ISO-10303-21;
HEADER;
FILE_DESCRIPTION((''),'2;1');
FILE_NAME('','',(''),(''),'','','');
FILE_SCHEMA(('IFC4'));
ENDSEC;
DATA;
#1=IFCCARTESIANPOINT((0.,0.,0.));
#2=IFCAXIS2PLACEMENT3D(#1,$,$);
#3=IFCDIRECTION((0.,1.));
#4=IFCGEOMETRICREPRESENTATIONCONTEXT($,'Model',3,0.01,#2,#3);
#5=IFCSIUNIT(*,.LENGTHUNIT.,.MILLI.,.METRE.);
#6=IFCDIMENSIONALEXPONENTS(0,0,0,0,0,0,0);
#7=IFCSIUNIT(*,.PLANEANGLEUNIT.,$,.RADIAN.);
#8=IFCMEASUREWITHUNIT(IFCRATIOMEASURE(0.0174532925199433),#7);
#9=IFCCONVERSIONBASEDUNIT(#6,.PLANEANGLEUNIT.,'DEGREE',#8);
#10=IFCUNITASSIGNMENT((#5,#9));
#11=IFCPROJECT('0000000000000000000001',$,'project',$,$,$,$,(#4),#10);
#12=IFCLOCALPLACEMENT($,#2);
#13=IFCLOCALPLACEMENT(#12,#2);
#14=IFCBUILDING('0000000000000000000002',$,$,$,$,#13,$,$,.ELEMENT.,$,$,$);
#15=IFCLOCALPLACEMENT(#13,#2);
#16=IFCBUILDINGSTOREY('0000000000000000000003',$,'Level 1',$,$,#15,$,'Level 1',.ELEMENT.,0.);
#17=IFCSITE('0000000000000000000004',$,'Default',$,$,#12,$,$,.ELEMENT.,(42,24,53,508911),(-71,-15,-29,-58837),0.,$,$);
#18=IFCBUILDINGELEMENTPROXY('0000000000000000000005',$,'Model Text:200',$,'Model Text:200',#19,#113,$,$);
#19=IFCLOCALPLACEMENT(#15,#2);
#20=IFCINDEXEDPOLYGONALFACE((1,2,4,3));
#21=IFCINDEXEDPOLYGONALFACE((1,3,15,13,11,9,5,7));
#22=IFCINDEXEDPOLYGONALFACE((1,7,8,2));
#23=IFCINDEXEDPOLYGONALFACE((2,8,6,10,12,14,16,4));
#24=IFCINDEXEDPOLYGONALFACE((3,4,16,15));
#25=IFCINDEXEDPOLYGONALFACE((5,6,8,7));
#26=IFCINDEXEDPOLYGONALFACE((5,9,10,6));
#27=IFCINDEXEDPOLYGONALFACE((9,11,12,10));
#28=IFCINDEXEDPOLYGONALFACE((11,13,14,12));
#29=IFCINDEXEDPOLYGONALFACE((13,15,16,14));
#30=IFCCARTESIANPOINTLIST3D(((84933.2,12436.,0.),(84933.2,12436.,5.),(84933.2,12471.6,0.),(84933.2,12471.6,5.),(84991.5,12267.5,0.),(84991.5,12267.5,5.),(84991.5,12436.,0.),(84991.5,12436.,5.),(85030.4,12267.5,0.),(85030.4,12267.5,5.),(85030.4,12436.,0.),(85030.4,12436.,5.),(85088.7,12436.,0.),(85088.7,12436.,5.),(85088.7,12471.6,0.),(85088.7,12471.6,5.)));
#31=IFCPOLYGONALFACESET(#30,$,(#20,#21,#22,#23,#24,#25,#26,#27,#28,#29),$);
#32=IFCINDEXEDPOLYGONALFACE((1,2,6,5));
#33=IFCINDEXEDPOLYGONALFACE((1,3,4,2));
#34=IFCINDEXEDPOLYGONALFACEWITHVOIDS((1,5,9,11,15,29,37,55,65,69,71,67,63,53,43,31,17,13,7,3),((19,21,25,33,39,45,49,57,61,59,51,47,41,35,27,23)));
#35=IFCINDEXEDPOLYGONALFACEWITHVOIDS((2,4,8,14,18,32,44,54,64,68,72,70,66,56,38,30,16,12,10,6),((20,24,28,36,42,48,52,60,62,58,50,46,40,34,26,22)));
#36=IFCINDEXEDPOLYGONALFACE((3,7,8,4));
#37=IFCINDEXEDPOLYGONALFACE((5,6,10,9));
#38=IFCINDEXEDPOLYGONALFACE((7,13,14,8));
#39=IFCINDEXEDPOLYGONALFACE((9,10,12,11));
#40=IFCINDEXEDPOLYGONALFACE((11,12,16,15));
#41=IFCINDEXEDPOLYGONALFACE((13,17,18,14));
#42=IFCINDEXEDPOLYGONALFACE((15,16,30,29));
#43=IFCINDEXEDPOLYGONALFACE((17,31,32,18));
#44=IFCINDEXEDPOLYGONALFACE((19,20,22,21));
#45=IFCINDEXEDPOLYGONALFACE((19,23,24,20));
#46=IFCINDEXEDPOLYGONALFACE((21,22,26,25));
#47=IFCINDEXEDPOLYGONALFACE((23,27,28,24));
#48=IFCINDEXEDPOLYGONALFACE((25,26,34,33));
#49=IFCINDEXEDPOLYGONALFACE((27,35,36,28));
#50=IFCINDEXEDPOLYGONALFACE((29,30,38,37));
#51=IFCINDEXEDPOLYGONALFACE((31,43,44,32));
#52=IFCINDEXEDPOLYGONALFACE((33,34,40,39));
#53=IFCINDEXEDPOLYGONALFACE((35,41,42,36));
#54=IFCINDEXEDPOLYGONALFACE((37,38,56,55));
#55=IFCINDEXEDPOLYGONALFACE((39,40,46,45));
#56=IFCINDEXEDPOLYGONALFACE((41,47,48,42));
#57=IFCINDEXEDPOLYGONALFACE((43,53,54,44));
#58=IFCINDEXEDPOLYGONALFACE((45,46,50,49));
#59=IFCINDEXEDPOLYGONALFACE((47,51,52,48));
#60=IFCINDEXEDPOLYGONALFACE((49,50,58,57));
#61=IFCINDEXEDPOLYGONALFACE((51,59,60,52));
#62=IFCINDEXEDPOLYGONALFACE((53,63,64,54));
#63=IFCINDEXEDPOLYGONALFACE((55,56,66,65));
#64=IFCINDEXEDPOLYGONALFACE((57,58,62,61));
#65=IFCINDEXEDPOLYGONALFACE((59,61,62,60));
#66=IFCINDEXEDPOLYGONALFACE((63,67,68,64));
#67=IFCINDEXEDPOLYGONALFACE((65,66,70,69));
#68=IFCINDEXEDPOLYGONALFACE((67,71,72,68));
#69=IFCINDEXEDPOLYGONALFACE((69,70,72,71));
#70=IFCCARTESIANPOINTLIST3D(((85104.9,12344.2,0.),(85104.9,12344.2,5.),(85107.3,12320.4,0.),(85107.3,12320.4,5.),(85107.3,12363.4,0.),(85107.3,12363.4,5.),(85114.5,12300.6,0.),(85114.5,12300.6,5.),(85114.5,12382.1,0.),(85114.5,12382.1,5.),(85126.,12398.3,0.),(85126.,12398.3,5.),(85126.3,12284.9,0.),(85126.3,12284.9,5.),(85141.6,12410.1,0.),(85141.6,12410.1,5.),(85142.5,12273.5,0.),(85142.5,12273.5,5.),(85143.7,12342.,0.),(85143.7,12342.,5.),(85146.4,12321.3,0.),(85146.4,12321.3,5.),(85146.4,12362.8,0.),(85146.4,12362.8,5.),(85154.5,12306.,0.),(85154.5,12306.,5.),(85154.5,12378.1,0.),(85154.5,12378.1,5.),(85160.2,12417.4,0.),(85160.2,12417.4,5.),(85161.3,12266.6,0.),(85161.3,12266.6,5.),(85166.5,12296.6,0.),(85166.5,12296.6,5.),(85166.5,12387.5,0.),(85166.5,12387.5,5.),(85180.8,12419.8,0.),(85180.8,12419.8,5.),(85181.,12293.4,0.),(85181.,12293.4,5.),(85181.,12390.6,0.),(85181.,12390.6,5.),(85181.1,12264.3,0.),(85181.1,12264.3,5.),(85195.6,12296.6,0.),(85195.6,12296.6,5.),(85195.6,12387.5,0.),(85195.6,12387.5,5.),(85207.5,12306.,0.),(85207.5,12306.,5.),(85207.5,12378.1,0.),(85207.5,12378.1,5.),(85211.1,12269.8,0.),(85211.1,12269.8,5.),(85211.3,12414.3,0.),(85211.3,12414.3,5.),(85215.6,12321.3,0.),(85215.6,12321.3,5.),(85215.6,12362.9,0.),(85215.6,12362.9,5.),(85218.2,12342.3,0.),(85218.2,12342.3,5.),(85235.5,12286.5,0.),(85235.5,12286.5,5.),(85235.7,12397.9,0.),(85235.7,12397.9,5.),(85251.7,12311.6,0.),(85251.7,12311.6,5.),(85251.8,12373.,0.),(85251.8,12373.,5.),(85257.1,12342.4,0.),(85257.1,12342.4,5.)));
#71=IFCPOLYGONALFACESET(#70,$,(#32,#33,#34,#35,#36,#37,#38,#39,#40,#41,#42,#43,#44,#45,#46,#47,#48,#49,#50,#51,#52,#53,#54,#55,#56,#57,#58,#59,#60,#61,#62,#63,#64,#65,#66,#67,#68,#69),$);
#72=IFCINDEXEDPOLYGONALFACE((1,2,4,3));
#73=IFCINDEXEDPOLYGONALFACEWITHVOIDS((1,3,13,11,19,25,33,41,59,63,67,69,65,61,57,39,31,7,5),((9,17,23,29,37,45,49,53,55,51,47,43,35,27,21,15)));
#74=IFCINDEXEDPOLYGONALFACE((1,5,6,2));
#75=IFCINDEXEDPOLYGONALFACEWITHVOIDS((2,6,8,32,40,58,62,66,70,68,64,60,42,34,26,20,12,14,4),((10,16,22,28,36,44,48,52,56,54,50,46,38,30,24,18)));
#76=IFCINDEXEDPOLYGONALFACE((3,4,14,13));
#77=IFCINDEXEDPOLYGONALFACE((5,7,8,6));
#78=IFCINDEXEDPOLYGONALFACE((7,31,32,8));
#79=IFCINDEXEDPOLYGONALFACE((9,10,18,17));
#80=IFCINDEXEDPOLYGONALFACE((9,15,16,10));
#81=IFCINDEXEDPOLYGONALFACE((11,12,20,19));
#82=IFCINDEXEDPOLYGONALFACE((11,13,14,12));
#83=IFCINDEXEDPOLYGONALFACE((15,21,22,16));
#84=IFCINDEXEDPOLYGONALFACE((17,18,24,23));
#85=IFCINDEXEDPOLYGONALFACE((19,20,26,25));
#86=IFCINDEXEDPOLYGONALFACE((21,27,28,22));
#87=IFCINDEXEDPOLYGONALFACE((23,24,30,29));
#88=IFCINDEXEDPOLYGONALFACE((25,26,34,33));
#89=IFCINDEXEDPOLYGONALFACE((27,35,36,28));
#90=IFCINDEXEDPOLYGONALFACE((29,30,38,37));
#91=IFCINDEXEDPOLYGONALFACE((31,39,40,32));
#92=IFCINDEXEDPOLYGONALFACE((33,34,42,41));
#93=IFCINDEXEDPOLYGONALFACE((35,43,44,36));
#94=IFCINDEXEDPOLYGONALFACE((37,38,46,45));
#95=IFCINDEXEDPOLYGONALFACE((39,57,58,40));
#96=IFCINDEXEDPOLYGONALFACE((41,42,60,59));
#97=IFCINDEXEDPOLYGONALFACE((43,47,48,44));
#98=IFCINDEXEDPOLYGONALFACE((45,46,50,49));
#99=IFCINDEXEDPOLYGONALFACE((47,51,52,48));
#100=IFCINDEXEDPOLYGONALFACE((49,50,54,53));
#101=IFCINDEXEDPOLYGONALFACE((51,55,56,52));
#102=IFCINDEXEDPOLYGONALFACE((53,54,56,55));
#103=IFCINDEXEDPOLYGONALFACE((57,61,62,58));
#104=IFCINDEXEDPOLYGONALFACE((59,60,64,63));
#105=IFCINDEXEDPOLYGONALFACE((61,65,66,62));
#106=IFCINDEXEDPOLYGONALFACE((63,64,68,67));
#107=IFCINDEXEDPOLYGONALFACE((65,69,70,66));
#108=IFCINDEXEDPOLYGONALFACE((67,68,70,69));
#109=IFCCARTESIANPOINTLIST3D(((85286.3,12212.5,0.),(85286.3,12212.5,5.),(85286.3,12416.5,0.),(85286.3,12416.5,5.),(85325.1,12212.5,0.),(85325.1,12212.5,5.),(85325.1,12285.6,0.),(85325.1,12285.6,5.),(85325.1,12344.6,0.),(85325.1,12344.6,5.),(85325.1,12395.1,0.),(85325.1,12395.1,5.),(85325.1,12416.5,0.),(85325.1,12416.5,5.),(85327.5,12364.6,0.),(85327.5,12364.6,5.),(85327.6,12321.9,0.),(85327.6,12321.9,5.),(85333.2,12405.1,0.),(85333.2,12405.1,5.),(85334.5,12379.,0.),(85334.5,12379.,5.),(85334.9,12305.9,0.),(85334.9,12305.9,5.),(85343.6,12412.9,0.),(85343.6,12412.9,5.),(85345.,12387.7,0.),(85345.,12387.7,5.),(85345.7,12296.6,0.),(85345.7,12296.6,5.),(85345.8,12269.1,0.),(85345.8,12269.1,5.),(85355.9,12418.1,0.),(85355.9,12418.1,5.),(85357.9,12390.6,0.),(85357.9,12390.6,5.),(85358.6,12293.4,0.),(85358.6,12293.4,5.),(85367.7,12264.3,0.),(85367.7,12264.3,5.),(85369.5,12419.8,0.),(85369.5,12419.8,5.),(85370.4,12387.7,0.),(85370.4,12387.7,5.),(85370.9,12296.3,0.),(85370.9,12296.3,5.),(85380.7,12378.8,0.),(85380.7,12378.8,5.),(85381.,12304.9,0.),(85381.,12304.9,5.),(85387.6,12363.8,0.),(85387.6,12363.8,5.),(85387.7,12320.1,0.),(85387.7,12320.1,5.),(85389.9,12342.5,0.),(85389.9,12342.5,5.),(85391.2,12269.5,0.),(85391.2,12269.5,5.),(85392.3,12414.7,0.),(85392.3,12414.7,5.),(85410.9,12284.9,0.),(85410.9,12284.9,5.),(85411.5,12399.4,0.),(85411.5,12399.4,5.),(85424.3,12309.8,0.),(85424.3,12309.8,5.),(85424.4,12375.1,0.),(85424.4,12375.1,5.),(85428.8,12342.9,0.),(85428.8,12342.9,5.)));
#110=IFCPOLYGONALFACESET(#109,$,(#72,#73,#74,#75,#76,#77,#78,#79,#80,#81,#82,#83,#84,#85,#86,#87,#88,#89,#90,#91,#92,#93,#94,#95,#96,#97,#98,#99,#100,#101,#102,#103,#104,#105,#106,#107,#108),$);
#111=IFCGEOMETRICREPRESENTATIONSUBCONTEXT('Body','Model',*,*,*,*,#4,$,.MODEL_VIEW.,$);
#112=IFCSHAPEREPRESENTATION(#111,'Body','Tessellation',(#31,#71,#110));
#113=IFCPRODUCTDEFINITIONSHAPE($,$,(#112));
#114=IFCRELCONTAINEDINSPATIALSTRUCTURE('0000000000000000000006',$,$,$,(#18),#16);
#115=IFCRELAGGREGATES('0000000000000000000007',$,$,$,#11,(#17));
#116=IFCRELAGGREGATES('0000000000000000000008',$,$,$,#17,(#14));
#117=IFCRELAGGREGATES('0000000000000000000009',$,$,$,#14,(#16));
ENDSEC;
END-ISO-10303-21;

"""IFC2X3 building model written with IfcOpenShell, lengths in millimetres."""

from ifc_helpers import new_model, entity, si_unit, converted_unit, direction, frame, origin, place, context, subcontext, project, spatial, polyline, outline, extrude, element, save


model = new_model("IFC2X3")

# Units and contexts
model_context = context("Model", 3, precision=0.01, world=origin(), true_north=direction((0.0, 1.0)))
body_context = subcontext(model_context, "Body", "Model", "MODEL_VIEW")
ifc_project = project(units=[si_unit("LENGTHUNIT", "METRE", prefix="MILLI"), converted_unit("PLANEANGLEUNIT", "DEGREE", entity("IfcRatioMeasure", 0.0174532925199433), si_unit("PLANEANGLEUNIT", "RADIAN"), dimensions=[0, 0, 0, 0, 0, 0, 0])], contexts=[model_context])

# Site, building, storey
site_placement = place(None, origin())
site = spatial("IfcSite", under=ifc_project, at=site_placement, Name="Default", CompositionType="ELEMENT", RefLatitude=(42, 24, 53, 508911), RefLongitude=(-71, -15, -29, -58837), RefElevation=0.0)
building_placement = place(site_placement, origin())
building = spatial("IfcBuilding", under=site, at=building_placement, CompositionType="ELEMENT")
storey_placement = place(building_placement, origin())
storey = spatial("IfcBuildingStorey", under=building, at=storey_placement, Name="Level 1", LongName="Level 1", CompositionType="ELEMENT", Elevation=0.0)

# Building element proxy
proxy_1_placement = place(storey_placement, origin())
element("IfcBuildingElementProxy", 1, at=proxy_1_placement, inside=storey, Name="Model Text:200", ObjectType="Model Text:200", context=body_context, shape_type="SweptSolid", body=[
    extrude(outline(polyline([(-19.4, -135.2), (19.4, -135.2), (19.4, 33.2), (77.7, 33.2), (77.7, 68.8), (-77.7, 68.8), (-77.7, 33.2), (-19.4, 33.2), (-19.4, -135.2)])), frame((85010.9, 12402.8, 0.0)), (0.0, 0.0, 1.0), 5.0),
    extrude(outline(polyline([(-8.8, -65.7), (15.1, -65.7), (35.5, -60.5), (52.3, -50.4), (65.3, -35.4), (74.1, -17.3), (78.4, 2.1), (75.9, 32.5), (61.8, 58.5), (38.4, 77.1), (8.3, 85.6), (-22.7, 83.3), (-49.0, 69.9), (-67.8, 47.3), (-76.3, 17.5), (-76.0, -3.3), (-70.7, -22.5), (-60.5, -39.2), (-45.5, -52.3), (-27.7, -61.4), (-8.8, -65.7)]), holes=[polyline([(-2.7, -27.2), (-23.1, -22.5), (-37.5, -12.9), (-45.7, 0.0), (-47.3, 14.8), (-42.7, 28.9), (-32.2, 39.9), (-16.3, 46.3), (4.5, 46.9), (25.1, 42.1), (39.6, 32.6), (47.7, 19.7), (49.4, 5.0), (44.8, -9.2), (34.2, -20.2), (18.2, -26.7), (-2.7, -27.2)])]), frame((85171.1, 12342.1, 0.0), z_axis=(0.0, 0.0, 1.0), x_axis=(0.100608, -0.994926, 0.0)), (0.0, 0.0, 1.0), 5.0),
    extrude(outline(polyline([(-73.1, -75.4), (130.9, -75.4), (130.9, -36.6), (57.8, -36.6), (74.3, -15.9), (79.1, 6.0), (73.9, 29.5), (58.4, 49.2), (33.6, 62.6), (0.5, 67.1), (-31.8, 62.8), (-56.1, 49.8), (-71.3, 30.7), (-76.4, 7.8), (-74.7, -5.8), (-69.6, -18.1), (-61.7, -28.5), (-51.7, -36.6), (-73.1, -36.6), (-73.1, -75.4)]), holes=[polyline([(-1.2, -36.6), (-21.2, -34.2), (-35.6, -27.2), (-44.3, -16.7), (-47.2, -3.8), (-44.3, 8.7), (-35.4, 19.0), (-20.4, 25.9), (0.8, 28.2), (23.3, 26.0), (38.5, 19.3), (47.1, 9.2), (49.9, -3.1), (46.8, -16.0), (37.4, -26.8), (21.5, -34.1), (-1.2, -36.6)])]), frame((85361.7, 12343.4, 0.0), z_axis=(0.0, 0.0, 1.0), x_axis=(0.0, -1.0, 0.0)), (0.0, 0.0, 1.0), 5.0),
])

save(model, "model.ifc")
